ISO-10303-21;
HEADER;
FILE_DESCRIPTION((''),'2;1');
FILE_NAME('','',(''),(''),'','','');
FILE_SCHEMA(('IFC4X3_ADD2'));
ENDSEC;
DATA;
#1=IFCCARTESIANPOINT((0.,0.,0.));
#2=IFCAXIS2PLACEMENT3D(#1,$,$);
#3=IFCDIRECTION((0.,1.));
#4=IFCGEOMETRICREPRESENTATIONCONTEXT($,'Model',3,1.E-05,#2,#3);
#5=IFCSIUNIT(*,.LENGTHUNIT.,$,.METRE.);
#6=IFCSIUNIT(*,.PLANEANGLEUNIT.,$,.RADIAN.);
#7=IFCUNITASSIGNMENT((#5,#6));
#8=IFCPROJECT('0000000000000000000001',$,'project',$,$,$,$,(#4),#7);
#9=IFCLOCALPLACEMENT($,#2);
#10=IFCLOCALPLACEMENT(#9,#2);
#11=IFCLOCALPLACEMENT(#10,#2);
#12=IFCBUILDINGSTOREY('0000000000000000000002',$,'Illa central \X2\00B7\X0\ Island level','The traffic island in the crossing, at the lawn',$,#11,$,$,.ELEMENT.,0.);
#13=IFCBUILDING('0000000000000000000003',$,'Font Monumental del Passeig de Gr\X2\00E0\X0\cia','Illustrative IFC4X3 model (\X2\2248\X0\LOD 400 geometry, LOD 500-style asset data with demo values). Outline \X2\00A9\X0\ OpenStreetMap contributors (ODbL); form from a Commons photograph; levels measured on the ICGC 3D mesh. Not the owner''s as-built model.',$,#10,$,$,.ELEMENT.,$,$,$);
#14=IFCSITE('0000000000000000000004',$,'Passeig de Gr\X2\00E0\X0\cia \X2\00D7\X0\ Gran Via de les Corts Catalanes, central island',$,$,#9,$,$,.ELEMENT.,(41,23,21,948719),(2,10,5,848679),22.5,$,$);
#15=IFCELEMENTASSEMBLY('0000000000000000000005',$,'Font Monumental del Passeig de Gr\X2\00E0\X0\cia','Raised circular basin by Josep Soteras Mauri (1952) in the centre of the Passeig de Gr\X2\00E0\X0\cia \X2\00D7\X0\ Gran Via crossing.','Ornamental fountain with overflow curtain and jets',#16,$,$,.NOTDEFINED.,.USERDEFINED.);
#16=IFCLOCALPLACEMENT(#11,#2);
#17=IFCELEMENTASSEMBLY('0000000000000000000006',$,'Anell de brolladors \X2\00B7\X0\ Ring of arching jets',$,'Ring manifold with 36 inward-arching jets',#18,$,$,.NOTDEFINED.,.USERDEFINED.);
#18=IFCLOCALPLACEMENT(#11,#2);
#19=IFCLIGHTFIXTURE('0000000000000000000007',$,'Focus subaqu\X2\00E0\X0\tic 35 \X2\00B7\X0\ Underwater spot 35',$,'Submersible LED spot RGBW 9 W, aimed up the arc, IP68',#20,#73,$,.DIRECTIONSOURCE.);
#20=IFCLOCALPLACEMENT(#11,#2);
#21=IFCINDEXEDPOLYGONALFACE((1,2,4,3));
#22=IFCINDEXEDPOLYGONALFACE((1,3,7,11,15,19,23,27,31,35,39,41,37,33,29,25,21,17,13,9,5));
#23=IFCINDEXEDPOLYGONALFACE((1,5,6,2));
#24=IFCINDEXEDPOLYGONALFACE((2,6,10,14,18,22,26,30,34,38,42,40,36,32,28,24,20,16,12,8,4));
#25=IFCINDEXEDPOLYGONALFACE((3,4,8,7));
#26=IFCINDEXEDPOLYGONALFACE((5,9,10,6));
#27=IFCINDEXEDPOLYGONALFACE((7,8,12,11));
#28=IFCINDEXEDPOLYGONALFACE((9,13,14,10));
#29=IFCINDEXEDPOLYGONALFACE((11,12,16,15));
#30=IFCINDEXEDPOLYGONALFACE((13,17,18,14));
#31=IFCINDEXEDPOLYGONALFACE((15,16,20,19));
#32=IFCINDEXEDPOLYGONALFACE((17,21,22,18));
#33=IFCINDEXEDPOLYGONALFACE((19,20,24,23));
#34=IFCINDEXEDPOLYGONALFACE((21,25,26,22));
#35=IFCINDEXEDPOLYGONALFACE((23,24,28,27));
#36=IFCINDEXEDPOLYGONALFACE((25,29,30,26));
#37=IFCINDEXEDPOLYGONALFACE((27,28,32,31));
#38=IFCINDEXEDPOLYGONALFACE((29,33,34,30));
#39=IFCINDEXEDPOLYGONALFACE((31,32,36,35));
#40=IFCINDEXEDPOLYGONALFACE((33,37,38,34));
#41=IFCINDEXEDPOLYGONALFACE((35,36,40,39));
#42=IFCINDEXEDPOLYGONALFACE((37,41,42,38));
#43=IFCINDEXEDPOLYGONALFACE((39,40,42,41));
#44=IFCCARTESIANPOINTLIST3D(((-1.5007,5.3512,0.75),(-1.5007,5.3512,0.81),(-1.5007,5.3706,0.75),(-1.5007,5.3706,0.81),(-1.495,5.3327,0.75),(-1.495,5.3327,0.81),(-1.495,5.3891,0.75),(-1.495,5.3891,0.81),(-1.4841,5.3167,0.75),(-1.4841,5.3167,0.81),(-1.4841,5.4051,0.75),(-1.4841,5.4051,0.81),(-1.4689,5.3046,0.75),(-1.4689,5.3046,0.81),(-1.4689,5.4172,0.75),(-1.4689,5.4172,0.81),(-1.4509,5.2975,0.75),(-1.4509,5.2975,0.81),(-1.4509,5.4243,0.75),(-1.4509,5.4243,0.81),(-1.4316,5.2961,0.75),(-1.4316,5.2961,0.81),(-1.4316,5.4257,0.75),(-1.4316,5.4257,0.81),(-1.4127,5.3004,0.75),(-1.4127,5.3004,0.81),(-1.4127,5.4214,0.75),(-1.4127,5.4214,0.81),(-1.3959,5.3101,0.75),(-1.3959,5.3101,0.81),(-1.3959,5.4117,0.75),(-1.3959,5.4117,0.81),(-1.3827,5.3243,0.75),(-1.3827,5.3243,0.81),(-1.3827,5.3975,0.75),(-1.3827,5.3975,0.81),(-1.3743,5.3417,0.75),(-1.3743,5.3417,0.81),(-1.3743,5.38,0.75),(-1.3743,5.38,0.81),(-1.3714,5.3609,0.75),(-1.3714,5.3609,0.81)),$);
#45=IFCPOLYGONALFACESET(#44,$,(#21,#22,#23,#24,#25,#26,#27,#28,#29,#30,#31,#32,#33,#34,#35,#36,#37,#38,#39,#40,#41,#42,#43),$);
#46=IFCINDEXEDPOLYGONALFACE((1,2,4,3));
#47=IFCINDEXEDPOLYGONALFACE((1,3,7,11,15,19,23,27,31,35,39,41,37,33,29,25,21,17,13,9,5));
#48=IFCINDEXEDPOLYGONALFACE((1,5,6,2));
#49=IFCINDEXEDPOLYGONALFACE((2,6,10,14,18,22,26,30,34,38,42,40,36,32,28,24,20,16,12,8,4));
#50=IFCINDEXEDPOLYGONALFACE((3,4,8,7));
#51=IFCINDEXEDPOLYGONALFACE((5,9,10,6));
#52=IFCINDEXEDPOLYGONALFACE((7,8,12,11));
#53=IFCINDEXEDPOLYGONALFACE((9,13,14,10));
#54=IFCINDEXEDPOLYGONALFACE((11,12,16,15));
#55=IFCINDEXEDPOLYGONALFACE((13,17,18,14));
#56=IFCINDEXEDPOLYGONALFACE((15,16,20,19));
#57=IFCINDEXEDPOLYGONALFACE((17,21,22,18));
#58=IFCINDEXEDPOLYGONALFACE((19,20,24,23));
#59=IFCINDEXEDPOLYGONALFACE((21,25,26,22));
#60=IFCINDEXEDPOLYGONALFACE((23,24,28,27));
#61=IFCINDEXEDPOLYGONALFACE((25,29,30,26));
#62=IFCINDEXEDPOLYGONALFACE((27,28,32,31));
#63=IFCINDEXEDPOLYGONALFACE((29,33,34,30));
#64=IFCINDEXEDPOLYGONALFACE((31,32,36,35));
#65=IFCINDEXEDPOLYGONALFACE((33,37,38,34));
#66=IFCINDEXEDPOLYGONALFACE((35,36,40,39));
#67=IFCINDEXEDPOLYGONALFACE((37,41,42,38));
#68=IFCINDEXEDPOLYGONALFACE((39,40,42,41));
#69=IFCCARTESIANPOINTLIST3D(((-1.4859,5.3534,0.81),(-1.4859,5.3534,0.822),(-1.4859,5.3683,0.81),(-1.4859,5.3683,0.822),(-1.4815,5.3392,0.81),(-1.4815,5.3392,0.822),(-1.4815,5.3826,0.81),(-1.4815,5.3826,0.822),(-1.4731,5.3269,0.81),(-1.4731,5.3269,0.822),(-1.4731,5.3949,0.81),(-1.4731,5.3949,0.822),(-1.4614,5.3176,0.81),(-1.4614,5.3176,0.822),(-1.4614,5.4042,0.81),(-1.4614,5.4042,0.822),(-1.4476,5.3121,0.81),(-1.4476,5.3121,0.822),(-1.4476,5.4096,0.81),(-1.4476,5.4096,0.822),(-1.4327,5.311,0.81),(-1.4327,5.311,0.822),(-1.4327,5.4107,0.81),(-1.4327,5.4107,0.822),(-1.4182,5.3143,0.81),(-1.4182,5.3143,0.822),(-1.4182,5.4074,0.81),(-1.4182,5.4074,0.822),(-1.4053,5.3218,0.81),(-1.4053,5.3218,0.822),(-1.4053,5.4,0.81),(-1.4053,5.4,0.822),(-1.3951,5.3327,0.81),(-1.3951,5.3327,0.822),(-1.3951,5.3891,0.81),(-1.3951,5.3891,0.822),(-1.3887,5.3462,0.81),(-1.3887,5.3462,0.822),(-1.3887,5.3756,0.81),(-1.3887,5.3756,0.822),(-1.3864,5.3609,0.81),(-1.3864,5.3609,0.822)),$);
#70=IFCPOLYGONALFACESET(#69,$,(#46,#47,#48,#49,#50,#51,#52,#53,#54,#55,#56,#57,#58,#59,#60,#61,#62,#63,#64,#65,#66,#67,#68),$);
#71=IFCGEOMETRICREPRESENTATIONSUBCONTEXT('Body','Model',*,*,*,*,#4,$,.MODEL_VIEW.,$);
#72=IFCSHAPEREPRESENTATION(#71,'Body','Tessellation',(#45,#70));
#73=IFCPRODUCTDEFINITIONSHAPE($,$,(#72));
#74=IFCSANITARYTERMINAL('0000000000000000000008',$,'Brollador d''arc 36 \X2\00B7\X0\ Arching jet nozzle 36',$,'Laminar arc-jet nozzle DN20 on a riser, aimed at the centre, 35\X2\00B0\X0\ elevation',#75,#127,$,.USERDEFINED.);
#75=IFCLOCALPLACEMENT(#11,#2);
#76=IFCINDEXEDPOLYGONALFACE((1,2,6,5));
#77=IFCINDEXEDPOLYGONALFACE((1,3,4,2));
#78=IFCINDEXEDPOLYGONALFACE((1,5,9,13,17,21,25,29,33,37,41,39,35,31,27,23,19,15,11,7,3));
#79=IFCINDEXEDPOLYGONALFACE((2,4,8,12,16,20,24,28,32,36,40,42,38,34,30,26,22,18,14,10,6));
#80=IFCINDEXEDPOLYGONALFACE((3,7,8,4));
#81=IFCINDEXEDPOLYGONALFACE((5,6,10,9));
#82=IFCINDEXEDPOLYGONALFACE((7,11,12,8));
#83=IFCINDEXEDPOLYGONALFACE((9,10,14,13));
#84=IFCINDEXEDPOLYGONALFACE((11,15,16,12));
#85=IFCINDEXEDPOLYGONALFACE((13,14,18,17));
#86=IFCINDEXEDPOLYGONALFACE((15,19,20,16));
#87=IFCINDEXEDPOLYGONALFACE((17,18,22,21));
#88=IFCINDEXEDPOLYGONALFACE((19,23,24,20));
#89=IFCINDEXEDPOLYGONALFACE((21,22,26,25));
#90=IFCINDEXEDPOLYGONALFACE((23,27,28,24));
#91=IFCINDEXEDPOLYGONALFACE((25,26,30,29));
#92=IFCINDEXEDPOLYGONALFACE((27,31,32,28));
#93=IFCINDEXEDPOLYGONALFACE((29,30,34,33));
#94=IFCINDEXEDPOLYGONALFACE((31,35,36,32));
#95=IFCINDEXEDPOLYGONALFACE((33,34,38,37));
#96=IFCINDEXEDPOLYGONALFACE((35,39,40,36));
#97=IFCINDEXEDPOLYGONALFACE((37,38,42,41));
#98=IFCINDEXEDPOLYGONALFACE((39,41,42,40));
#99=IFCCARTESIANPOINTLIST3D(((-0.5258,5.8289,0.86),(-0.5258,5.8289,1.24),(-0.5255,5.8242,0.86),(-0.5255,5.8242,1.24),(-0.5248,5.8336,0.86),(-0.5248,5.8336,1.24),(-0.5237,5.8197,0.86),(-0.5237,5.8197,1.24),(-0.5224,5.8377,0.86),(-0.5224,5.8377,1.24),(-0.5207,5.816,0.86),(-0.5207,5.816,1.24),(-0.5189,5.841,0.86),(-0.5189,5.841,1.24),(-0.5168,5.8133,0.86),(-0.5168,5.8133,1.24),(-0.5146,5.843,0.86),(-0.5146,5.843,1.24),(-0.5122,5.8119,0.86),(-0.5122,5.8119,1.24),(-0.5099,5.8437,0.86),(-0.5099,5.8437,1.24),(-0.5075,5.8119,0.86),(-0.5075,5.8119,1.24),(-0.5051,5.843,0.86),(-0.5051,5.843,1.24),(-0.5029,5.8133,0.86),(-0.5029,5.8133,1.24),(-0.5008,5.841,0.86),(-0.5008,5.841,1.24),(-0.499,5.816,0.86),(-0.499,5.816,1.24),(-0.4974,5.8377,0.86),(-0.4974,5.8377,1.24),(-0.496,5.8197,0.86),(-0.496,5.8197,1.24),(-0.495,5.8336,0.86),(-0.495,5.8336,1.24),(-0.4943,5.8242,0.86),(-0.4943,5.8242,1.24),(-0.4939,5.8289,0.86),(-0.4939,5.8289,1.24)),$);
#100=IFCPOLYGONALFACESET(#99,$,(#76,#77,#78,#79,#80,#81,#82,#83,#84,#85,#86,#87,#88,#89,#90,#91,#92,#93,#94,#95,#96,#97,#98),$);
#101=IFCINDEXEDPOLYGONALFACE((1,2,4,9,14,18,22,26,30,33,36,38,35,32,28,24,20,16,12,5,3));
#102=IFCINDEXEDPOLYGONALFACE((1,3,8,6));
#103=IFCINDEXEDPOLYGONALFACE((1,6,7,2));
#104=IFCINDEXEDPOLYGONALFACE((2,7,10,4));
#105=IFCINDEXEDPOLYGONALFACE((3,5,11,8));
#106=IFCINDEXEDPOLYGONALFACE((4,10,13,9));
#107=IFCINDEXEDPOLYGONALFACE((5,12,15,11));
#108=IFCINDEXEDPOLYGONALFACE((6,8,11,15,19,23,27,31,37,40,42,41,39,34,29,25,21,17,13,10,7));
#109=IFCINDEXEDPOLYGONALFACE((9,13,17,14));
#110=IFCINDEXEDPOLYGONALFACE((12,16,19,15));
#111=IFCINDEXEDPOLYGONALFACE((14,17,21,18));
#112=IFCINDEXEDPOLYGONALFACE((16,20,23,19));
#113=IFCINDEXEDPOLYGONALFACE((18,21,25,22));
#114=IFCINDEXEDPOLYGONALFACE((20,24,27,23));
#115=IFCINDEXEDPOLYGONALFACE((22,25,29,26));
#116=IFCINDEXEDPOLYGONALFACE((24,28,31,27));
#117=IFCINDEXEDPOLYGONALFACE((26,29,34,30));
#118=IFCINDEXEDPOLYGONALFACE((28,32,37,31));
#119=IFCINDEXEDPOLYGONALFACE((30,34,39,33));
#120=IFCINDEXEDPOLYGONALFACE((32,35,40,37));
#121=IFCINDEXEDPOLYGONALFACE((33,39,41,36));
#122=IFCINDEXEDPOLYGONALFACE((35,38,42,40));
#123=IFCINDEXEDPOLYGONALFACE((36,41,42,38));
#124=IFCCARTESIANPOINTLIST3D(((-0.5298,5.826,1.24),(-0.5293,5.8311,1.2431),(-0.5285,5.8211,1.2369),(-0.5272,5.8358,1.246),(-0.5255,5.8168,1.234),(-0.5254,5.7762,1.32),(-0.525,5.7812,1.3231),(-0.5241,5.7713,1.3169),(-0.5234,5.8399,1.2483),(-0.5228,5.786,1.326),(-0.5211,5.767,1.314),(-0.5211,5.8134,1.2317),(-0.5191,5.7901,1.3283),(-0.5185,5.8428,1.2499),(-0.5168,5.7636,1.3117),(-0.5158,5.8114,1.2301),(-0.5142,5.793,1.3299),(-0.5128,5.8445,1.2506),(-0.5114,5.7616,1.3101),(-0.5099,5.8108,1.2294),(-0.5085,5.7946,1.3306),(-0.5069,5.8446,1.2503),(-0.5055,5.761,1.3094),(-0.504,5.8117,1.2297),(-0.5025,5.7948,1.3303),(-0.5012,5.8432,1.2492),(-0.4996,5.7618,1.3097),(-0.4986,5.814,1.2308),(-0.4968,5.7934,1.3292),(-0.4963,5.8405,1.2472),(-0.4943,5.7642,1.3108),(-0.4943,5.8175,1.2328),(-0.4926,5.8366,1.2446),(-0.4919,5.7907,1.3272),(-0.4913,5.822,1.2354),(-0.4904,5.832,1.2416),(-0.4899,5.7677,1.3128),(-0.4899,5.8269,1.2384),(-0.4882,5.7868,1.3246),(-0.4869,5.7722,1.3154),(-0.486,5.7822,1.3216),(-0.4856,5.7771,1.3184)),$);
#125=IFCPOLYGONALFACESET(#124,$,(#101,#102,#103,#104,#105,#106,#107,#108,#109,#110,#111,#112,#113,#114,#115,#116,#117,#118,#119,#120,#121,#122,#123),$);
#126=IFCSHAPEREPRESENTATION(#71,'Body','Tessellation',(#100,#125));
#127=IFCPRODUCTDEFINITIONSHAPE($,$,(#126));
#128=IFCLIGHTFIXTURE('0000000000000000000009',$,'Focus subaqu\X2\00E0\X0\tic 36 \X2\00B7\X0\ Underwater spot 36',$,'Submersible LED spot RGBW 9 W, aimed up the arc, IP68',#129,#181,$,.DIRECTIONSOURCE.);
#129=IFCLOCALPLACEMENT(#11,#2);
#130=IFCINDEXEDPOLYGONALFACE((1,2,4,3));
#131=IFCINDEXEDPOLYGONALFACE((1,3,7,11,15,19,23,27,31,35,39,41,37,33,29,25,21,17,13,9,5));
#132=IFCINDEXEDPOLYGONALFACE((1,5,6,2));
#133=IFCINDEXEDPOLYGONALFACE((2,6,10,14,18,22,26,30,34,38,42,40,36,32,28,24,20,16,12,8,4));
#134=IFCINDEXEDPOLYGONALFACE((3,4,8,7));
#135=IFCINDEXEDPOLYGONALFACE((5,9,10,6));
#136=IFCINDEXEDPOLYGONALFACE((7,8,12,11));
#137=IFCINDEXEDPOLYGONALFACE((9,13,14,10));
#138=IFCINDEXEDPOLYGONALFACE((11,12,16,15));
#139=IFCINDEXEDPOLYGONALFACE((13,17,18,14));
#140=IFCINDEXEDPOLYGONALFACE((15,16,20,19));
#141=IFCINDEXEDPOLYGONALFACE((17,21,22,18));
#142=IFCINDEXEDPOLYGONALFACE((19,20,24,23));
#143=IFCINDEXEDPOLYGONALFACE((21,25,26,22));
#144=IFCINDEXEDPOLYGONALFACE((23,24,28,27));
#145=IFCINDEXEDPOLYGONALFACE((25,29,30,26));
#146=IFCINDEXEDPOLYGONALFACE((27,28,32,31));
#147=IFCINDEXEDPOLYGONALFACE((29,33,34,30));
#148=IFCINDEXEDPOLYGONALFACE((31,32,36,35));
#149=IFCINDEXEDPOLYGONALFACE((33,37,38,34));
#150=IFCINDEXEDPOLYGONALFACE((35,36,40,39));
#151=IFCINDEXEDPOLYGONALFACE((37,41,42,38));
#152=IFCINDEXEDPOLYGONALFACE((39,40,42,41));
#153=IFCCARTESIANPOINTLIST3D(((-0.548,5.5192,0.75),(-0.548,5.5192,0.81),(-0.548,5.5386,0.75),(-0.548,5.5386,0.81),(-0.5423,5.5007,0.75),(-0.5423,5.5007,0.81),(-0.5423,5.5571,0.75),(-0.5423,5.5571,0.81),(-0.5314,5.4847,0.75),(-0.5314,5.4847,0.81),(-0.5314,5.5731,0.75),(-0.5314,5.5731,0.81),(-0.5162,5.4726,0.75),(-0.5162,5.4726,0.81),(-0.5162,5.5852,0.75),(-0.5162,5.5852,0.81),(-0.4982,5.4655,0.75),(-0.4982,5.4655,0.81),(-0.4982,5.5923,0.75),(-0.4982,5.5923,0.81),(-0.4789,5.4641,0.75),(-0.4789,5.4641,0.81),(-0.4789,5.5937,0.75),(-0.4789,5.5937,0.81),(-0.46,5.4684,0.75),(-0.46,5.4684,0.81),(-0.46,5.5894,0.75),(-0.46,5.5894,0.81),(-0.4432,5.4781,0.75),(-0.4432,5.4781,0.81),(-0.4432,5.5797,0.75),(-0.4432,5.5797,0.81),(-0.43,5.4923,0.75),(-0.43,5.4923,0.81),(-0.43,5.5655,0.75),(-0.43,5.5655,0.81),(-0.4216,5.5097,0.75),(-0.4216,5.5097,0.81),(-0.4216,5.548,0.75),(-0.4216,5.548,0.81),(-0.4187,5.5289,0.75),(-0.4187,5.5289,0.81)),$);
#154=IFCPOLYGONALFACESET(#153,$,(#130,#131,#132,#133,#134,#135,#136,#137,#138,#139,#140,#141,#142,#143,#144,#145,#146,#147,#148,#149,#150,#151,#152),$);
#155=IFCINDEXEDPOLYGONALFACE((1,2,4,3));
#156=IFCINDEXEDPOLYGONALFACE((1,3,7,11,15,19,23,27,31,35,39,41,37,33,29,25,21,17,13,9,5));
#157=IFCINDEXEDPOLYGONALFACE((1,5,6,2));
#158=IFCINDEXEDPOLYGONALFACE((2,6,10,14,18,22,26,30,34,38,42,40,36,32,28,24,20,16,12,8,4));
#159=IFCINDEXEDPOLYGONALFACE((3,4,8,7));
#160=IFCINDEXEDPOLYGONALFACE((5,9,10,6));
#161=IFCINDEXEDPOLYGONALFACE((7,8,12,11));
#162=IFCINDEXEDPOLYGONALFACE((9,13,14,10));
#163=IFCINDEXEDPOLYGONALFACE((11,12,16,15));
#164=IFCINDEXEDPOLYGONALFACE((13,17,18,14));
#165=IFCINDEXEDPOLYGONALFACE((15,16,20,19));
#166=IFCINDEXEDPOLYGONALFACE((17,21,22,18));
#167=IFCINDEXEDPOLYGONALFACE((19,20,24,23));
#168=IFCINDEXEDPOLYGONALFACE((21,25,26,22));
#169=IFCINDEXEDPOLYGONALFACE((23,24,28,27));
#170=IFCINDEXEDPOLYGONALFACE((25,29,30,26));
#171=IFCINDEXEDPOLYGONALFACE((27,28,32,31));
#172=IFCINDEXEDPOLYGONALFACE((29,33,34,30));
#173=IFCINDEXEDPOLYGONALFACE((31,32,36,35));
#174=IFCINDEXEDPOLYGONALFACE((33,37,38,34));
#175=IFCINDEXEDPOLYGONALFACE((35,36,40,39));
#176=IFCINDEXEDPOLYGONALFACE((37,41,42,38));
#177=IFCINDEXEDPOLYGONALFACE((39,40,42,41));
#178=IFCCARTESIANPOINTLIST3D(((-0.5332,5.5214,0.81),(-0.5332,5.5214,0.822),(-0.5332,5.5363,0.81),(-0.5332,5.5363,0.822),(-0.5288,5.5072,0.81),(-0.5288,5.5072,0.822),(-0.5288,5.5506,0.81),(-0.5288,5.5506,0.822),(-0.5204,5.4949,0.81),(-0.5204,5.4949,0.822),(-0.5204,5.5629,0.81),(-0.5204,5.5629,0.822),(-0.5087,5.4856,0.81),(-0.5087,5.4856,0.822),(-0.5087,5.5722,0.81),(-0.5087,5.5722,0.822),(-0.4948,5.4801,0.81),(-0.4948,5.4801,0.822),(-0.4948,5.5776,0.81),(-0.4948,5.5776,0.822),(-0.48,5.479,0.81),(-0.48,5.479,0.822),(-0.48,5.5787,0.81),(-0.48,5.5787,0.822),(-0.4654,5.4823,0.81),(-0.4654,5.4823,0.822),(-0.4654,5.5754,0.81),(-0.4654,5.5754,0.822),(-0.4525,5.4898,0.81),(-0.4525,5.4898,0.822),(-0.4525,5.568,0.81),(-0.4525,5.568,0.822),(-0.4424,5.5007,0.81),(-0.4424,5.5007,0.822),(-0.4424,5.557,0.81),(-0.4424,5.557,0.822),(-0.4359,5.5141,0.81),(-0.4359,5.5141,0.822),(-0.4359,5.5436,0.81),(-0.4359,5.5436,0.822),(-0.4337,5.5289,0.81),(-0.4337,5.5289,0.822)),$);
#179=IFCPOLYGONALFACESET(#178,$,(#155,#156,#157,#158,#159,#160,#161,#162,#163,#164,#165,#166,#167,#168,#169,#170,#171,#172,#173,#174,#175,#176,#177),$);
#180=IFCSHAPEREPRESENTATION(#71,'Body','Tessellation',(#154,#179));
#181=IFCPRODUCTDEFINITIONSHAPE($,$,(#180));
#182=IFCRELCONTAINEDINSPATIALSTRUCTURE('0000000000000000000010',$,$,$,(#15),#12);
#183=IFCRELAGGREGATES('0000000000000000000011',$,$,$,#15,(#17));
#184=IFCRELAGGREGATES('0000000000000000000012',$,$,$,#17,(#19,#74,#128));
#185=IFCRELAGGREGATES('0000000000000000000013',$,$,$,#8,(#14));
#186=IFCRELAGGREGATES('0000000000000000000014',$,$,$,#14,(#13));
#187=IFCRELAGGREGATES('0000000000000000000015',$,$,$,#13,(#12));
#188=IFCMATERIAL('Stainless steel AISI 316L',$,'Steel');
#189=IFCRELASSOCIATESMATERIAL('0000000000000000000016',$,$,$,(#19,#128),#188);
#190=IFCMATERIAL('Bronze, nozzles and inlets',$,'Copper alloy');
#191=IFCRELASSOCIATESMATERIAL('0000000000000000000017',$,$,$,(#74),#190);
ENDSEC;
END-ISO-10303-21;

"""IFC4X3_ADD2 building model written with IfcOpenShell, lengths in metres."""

from ifc_helpers import new_model, si_unit, direction, frame, origin, origin_2d_with_axis, place, context, subcontext, project, spatial, circle, extrude, material, element, aggregate, save


model = new_model("IFC4X3_ADD2")

# Units and contexts
model_context = context("Model", 3, precision=1e-05, world=origin(), true_north=direction((0.0, 1.0)))
body_context = subcontext(model_context, "Body", "Model", "MODEL_VIEW")
ifc_project = project(units=[si_unit("LENGTHUNIT", "METRE"), si_unit("PLANEANGLEUNIT", "RADIAN")], contexts=[model_context])

# Site, building, storey
site_placement = place(None, origin())
site = spatial("IfcSite", under=ifc_project, at=site_placement, Name="Passeig de Gràcia × Gran Via de les Corts Catalanes, central island", CompositionType="ELEMENT", RefLatitude=(41, 23, 21, 948719), RefLongitude=(2, 10, 5, 848679), RefElevation=22.5)
building_placement = place(site_placement, origin())
building = spatial("IfcBuilding", under=site, at=building_placement, Name="Font Monumental del Passeig de Gràcia", Description="Illustrative IFC4X3 model (≈LOD 400 geometry, LOD 500-style asset data with demo values). Outline © OpenStreetMap contributors (ODbL); form from a Commons photograph; levels measured on the ICGC 3D mesh. Not the owner's as-built model.", CompositionType="ELEMENT")
storey_placement = place(building_placement, origin())
storey = spatial("IfcBuildingStorey", under=building, at=storey_placement, Name="Illa central · Island level", Description="The traffic island in the crossing, at the lawn", CompositionType="ELEMENT", Elevation=0.0)

# Element assemblies, light fixtures, sanitary terminal
assembly_1_placement = place(building_placement, origin())
assembly_1 = element("IfcElementAssembly", 1, at=assembly_1_placement, inside=storey, Name="Font Monumental del Passeig de Gràcia", Description="Raised circular basin by Josep Soteras Mauri (1952) in the centre of the Passeig de Gràcia × Gran Via crossing.", ObjectType="Ornamental fountain with overflow curtain and jets", AssemblyPlace="NOTDEFINED", PredefinedType="USERDEFINED")
assembly_2_placement = place(building_placement, origin())
assembly_2 = element("IfcElementAssembly", 2, at=assembly_2_placement, Name="Anell de brolladors · Ring of arching jets", ObjectType="Ring manifold with 36 inward-arching jets", AssemblyPlace="NOTDEFINED", PredefinedType="USERDEFINED")
ifc_material_1 = material(Name="Stainless steel AISI 316L", Category="Steel")
ifc_material_2 = material(Name="Bronze, nozzles and inlets", Category="Copper alloy")
light_fixture_1_placement = place(building_placement, origin())
light_fixture_1 = element("IfcLightFixture", 3, at=light_fixture_1_placement, material=ifc_material_1, Name="Focus subaquàtic 35 · Underwater spot 35", ObjectType="Submersible LED spot RGBW 9 W, aimed up the arc, IP68", PredefinedType="DIRECTIONSOURCE", context=body_context, shape_type="SweptSolid", body=[
    extrude(circle(Radius=0.065, at=origin_2d_with_axis()), frame((-1.4364, 5.3609, 0.75)), (0.0, 0.0, 1.0), 0.06),
    extrude(circle(Radius=0.05, at=origin_2d_with_axis()), frame((-1.4364, 5.3609, 0.81)), (0.0, 0.0, 1.0), 0.012),
])
sanitary_terminal_1_placement = place(building_placement, origin())
sanitary_terminal_1 = element("IfcSanitaryTerminal", 4, at=sanitary_terminal_1_placement, material=ifc_material_2, Name="Brollador d'arc 36 · Arching jet nozzle 36", ObjectType="Laminar arc-jet nozzle DN20 on a riser, aimed at the centre, 35° elevation", PredefinedType="USERDEFINED", context=body_context, shape_type="SweptSolid", body=[
    extrude(circle(Radius=0.016, at=origin_2d_with_axis()), frame((-0.5099, 5.8277, 0.86), z_axis=(0.0, 0.0, 1.0), x_axis=(0.0, 1.0, 0.0)), (0.0, 0.0, 1.0), 0.38),
    extrude(circle(Radius=0.02, at=origin_2d_with_axis()), frame((-0.5099, 5.8277, 1.24), z_axis=(0.046192, -0.527982, 0.847998), x_axis=(-0.996195, -0.087156, 0.0)), (0.0, 0.0, 1.0), 0.0943),
])
light_fixture_2_placement = place(building_placement, origin())
light_fixture_2 = element("IfcLightFixture", 5, at=light_fixture_2_placement, material=ifc_material_1, Name="Focus subaquàtic 36 · Underwater spot 36", ObjectType="Submersible LED spot RGBW 9 W, aimed up the arc, IP68", PredefinedType="DIRECTIONSOURCE", context=body_context, shape_type="SweptSolid", body=[
    extrude(circle(Radius=0.065, at=origin_2d_with_axis()), frame((-0.4837, 5.5289, 0.75)), (0.0, 0.0, 1.0), 0.06),
    extrude(circle(Radius=0.05, at=origin_2d_with_axis()), frame((-0.4837, 5.5289, 0.81)), (0.0, 0.0, 1.0), 0.012),
])
aggregate(assembly_1, [assembly_2])

aggregate(assembly_2, [light_fixture_1, sanitary_terminal_1, light_fixture_2])

save(model, "model.ifc")
